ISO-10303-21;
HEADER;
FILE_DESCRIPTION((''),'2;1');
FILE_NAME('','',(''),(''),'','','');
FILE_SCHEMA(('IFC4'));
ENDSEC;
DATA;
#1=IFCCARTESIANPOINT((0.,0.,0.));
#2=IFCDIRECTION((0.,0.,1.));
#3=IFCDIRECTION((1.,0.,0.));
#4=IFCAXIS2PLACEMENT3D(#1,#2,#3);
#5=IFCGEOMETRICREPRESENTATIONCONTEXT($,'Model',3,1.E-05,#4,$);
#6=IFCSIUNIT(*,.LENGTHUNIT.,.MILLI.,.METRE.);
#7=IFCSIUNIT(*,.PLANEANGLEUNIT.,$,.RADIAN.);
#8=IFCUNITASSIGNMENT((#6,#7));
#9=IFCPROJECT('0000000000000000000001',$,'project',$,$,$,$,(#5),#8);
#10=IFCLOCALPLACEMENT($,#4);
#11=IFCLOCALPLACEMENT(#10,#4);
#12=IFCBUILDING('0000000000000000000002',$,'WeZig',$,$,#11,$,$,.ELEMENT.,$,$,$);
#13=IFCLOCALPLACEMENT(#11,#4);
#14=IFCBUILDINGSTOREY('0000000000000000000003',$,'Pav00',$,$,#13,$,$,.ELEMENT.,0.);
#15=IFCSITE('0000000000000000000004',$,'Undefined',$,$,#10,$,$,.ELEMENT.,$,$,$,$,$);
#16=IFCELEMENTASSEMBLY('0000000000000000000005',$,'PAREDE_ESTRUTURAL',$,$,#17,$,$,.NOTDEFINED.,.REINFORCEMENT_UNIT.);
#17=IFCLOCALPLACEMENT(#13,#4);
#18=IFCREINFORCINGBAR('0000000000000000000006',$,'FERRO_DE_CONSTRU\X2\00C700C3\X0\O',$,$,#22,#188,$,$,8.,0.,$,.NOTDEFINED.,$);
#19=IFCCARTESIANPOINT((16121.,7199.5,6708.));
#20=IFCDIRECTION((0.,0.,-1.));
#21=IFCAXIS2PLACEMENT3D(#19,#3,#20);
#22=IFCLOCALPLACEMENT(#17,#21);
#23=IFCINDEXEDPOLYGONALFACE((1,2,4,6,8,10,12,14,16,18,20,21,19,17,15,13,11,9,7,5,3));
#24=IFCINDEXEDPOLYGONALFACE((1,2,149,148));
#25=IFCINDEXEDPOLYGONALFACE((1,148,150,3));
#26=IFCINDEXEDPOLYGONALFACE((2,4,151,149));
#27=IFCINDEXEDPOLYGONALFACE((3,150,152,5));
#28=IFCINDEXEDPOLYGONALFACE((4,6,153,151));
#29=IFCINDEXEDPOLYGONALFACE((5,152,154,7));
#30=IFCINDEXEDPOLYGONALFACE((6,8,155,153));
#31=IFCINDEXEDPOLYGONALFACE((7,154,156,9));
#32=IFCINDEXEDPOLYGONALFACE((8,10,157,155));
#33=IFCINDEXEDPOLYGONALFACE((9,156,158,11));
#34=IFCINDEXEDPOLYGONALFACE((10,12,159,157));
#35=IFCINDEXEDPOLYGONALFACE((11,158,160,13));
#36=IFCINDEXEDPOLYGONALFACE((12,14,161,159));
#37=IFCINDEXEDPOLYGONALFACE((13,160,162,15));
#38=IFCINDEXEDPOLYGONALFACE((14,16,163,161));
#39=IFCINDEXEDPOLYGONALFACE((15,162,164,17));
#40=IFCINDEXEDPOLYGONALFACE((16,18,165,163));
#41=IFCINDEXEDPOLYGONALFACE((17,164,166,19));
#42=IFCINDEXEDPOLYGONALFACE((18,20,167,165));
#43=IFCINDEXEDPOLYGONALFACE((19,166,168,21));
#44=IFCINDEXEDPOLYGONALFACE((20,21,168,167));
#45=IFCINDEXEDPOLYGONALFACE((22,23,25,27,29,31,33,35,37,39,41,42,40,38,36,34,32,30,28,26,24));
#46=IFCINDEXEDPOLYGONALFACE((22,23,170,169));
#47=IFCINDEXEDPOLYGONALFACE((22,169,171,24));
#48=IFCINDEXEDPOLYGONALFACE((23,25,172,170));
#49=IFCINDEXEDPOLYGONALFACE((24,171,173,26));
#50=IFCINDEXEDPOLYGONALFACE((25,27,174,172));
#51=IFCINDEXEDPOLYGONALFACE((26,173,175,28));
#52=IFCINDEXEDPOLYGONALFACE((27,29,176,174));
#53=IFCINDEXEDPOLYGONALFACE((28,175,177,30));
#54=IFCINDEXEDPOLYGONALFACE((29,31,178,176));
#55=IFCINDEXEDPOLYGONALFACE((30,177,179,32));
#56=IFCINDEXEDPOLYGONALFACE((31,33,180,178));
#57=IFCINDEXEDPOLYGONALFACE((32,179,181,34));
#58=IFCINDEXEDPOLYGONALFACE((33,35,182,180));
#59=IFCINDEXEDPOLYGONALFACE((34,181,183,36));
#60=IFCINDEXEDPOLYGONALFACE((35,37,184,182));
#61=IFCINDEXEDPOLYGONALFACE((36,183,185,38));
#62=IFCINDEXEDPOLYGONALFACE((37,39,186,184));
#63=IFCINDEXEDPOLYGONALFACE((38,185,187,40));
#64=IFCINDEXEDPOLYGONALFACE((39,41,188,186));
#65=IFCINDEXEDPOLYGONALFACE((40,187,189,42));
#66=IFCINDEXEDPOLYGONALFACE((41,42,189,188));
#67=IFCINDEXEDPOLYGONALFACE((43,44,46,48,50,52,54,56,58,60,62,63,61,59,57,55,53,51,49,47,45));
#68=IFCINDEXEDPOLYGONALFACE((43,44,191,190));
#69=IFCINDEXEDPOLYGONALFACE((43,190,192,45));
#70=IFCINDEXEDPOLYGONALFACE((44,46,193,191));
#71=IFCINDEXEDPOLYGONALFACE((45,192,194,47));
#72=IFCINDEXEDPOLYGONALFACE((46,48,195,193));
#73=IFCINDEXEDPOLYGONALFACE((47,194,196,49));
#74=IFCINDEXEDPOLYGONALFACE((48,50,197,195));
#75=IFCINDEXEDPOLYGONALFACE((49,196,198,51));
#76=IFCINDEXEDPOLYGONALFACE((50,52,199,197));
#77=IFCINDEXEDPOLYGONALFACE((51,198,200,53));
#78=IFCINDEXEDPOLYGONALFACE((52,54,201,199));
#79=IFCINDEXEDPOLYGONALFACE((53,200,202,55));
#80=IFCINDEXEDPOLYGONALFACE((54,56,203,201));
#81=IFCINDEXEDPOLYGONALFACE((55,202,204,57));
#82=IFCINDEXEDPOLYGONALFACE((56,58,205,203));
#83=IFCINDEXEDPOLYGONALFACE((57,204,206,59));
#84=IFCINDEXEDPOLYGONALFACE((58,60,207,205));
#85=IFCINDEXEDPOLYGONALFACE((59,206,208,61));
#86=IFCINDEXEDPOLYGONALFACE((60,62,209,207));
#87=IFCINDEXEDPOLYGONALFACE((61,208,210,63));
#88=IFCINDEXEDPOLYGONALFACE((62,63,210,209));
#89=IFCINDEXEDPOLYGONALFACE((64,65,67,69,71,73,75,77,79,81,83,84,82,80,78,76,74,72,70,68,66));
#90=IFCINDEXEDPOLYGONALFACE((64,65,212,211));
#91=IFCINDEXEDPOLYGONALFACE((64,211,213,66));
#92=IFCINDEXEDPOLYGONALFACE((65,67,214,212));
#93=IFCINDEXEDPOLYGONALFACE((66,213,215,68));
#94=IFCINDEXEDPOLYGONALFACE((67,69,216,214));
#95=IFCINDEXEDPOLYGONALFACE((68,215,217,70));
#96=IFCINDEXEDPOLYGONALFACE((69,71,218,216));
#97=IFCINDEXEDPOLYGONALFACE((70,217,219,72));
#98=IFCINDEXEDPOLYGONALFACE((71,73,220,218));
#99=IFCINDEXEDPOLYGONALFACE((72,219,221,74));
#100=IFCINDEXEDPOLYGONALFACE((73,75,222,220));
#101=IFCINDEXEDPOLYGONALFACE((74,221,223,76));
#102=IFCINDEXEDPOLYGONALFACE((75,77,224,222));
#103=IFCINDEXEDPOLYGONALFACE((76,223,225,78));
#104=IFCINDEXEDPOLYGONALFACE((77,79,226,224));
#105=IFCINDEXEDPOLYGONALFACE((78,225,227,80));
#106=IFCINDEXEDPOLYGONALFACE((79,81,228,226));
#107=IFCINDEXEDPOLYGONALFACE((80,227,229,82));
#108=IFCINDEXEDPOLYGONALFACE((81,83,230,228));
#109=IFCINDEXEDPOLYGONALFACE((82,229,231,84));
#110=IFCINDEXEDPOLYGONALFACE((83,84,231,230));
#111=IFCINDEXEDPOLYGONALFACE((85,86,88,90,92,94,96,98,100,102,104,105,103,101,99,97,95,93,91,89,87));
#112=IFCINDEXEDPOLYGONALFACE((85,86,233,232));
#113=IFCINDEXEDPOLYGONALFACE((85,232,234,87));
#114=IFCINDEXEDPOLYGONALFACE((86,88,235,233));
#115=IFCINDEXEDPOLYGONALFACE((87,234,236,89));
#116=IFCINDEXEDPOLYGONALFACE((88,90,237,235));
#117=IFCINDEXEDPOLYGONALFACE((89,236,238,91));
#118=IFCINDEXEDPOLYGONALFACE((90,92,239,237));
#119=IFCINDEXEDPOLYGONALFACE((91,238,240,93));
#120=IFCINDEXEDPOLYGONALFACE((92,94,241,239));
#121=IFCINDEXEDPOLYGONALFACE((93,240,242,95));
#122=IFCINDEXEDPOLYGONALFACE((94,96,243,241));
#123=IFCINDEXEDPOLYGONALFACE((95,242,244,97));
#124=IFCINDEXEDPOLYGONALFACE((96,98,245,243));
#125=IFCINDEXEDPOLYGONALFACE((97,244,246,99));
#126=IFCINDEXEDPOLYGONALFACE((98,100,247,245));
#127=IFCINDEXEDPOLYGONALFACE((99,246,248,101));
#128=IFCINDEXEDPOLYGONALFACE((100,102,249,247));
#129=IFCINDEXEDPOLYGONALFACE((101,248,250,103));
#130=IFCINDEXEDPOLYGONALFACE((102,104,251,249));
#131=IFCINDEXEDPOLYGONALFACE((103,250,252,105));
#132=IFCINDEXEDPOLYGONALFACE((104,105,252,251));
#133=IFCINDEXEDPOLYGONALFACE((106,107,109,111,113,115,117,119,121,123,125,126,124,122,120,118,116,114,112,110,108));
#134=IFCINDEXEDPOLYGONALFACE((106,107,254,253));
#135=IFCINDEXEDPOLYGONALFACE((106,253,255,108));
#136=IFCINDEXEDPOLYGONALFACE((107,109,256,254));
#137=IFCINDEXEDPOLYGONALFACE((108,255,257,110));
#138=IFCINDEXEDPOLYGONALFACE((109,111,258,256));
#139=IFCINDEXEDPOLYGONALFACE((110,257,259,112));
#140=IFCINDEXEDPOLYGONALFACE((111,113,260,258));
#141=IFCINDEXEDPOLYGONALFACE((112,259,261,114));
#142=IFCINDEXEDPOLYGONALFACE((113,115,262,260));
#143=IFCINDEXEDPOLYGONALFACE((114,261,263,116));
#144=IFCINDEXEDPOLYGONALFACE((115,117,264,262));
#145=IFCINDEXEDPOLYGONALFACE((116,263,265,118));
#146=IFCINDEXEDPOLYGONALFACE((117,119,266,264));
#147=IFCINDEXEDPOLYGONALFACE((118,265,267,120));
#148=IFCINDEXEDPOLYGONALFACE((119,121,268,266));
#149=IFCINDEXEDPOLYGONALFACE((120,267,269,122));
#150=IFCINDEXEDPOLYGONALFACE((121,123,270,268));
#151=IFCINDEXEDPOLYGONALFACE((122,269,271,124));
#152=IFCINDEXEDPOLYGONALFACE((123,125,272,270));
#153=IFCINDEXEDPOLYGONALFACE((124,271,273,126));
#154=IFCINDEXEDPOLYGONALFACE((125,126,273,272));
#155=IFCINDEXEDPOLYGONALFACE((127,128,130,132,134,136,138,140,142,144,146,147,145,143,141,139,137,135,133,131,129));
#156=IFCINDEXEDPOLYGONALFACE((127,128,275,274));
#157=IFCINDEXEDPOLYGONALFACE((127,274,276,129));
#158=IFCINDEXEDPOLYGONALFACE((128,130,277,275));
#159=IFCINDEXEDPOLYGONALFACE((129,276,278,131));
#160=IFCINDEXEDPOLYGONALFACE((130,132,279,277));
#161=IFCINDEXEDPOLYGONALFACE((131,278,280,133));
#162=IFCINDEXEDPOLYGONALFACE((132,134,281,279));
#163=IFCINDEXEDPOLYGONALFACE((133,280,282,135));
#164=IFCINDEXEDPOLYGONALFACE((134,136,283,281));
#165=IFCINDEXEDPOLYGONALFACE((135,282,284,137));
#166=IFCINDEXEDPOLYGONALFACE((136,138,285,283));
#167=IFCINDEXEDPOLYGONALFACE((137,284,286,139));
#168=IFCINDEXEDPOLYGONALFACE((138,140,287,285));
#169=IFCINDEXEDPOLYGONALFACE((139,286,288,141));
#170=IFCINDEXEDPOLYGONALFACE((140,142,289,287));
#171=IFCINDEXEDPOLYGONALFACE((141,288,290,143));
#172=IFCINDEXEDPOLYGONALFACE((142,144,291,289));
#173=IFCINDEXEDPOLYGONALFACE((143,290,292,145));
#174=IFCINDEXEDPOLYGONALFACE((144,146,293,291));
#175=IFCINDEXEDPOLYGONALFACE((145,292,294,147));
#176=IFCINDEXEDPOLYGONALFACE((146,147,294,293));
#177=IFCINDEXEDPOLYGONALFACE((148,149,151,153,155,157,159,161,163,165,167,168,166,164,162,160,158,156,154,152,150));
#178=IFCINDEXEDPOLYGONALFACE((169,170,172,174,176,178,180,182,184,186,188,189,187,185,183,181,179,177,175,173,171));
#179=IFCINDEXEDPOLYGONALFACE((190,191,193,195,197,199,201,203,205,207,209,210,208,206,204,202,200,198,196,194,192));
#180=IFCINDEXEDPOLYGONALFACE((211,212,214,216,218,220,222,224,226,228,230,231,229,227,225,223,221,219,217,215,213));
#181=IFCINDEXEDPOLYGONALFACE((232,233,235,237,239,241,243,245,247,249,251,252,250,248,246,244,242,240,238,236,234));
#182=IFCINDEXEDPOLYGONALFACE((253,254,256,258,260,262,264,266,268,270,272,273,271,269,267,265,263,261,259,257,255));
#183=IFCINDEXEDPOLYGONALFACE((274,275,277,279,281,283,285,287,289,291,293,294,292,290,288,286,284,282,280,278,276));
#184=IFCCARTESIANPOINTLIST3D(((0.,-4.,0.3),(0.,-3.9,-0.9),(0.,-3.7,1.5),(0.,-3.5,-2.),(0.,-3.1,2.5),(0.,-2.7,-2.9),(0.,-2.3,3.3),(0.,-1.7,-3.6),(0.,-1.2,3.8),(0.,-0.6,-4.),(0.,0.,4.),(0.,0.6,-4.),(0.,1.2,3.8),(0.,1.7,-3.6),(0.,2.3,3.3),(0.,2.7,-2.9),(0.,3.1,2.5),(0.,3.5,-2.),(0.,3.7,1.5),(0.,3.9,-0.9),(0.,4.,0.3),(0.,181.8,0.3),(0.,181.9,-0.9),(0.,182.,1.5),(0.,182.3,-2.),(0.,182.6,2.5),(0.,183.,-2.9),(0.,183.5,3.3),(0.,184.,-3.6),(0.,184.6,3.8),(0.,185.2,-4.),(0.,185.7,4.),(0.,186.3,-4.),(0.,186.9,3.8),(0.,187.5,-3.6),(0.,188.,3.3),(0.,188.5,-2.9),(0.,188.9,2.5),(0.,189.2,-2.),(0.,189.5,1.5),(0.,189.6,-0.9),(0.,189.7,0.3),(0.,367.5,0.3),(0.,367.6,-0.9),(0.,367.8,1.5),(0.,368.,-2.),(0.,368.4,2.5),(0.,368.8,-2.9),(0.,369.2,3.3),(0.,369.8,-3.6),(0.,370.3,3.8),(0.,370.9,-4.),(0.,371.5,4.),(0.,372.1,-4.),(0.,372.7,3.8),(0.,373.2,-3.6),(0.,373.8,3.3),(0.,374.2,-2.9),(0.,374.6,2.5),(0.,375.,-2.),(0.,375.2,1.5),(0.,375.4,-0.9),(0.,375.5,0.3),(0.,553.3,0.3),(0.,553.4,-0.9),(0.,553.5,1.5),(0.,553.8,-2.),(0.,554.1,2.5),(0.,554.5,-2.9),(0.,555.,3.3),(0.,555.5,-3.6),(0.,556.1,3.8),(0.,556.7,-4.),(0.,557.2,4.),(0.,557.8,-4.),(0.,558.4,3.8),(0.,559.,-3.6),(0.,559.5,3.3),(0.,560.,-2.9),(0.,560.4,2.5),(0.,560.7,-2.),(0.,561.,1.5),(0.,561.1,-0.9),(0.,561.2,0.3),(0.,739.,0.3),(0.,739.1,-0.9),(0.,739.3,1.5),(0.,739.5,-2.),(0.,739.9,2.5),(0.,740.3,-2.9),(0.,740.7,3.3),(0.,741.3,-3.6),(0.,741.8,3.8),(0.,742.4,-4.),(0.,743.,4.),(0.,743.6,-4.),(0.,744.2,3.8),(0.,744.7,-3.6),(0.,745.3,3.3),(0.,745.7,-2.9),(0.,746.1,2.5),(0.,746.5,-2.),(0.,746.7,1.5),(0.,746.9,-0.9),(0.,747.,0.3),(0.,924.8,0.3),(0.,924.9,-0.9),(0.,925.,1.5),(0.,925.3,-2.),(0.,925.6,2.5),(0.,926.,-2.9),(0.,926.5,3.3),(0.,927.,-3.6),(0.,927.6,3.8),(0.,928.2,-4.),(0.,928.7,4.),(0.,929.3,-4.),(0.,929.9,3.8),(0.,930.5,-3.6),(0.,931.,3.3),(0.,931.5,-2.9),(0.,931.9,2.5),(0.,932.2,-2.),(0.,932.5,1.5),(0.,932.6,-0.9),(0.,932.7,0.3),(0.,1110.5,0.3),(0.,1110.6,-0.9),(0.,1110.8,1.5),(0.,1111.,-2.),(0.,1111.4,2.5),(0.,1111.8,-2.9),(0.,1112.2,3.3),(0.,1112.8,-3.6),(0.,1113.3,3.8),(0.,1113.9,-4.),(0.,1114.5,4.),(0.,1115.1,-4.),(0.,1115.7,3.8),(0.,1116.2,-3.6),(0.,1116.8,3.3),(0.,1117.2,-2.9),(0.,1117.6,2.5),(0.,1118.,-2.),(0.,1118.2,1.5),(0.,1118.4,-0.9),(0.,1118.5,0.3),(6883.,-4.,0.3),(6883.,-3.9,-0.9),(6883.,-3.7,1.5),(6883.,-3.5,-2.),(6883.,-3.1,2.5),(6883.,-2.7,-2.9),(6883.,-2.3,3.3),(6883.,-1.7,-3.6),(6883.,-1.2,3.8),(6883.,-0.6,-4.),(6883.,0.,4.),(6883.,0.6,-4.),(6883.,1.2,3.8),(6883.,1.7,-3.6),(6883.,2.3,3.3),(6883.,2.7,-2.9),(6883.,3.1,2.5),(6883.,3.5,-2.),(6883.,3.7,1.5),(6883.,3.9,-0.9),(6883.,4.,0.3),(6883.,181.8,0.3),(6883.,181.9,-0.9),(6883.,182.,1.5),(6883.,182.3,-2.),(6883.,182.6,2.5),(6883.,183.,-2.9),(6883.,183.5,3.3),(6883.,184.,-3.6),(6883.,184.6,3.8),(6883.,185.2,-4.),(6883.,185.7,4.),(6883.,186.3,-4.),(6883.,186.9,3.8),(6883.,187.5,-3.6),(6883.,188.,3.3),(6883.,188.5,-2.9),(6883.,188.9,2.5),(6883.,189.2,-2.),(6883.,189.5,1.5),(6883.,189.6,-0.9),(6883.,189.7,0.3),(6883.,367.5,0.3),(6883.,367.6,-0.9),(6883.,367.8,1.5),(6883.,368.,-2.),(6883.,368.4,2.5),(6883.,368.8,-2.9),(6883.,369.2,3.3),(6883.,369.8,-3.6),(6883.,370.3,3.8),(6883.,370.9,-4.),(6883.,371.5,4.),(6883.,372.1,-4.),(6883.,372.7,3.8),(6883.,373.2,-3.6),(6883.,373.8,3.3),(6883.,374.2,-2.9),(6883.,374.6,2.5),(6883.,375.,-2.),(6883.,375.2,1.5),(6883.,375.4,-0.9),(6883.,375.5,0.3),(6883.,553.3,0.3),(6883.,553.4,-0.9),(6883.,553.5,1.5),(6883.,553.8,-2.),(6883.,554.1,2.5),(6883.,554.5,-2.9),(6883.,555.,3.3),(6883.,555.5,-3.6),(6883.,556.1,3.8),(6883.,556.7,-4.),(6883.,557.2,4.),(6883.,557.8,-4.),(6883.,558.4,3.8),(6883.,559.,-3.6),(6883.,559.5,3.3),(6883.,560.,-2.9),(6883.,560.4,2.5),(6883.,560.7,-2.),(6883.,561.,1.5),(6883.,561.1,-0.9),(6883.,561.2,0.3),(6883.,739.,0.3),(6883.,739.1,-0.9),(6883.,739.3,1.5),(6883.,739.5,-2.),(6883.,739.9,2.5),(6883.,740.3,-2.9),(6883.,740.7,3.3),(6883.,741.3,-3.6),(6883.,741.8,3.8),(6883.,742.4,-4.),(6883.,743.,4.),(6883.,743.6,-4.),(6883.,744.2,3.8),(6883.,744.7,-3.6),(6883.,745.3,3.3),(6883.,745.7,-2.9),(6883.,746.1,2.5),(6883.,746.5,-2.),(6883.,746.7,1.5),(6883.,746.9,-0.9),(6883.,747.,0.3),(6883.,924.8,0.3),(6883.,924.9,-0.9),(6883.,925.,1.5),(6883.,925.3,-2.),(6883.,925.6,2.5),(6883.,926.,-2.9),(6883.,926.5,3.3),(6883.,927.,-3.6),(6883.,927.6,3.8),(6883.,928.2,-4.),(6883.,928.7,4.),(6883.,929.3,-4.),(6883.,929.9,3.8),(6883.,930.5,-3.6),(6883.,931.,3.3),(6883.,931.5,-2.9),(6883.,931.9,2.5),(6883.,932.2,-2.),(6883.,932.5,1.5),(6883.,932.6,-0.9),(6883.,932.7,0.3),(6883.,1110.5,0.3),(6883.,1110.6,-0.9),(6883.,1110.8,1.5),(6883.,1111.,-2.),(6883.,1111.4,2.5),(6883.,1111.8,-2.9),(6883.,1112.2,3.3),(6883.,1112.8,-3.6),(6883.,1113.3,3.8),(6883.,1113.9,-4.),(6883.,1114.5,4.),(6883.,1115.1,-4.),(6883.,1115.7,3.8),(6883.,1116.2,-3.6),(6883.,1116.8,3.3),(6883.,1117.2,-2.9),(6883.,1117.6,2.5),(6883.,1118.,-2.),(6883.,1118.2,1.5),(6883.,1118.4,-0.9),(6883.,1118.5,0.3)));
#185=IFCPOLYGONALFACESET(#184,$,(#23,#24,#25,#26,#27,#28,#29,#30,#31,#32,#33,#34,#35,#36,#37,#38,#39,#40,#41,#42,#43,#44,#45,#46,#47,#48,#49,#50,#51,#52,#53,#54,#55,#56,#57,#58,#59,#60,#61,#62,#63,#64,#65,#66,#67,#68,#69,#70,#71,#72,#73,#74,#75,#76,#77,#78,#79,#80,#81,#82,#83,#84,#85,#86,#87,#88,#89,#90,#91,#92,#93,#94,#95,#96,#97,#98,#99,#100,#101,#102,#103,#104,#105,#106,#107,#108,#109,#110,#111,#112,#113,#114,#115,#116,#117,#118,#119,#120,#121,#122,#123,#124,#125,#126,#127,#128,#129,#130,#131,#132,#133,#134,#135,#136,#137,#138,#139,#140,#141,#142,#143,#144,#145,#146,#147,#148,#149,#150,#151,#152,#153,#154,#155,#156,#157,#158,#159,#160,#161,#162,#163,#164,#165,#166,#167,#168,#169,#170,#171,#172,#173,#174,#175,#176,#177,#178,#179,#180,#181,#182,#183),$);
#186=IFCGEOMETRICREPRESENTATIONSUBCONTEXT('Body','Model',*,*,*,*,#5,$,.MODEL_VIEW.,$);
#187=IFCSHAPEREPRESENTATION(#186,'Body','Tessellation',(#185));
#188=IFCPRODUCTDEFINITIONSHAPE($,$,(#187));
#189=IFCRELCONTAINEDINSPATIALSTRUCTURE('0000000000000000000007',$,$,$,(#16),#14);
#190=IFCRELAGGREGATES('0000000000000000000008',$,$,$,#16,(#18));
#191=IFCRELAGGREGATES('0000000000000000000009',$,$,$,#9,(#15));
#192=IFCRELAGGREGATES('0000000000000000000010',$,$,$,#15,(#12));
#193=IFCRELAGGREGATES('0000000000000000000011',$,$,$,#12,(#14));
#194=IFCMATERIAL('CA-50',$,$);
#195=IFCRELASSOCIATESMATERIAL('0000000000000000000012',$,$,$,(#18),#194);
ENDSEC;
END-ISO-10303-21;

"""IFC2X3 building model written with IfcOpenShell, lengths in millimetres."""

from ifc_helpers import new_model, entity, si_unit, frame, origin_with_axes, place, context, subcontext, project, spatial, source, transform, mapped, material, element, aggregate, save


model = new_model("IFC2X3")

# Units and contexts
model_context = context("Model", 3, precision=1e-05, world=origin_with_axes())
body_context = subcontext(model_context, "Body", "Model", "MODEL_VIEW")
ifc_project = project(units=[si_unit("LENGTHUNIT", "METRE", prefix="MILLI"), si_unit("PLANEANGLEUNIT", "RADIAN")], contexts=[model_context])

# Site, building, storey
site_placement = place(None, origin_with_axes())
site = spatial("IfcSite", under=ifc_project, at=site_placement, Name="Undefined", CompositionType="ELEMENT")
building_placement = place(site_placement, origin_with_axes())
building = spatial("IfcBuilding", under=site, at=building_placement, Name="WeZig", CompositionType="ELEMENT")
storey_placement = place(building_placement, origin_with_axes())
storey = spatial("IfcBuildingStorey", under=building, at=storey_placement, Name="Pav00", CompositionType="ELEMENT", Elevation=0.0)

# Shared definitions
ifc_material_1 = material(Name="CA-50")

# Element assembly, reinforcing bar
assembly_1_placement = place(storey_placement, origin_with_axes())
assembly_1 = element("IfcElementAssembly", 1, at=assembly_1_placement, inside=storey, Name="PAREDE_ESTRUTURAL", AssemblyPlace="NOTDEFINED", PredefinedType="REINFORCEMENT_UNIT")
shared_shape_1 = source(origin_with_axes(), body_context, "Body", "AdvancedSweptSolid", [
    entity("IfcSweptDiskSolid", entity("IfcTrimmedCurve", entity("IfcLine", entity("IfcCartesianPoint", [0.0, 0.0, 0.0]), entity("IfcVector", entity("IfcDirection", [1.0, 0.0, 0.0]), 1.0)), [entity("IfcParameterValue", 0.0)], [entity("IfcParameterValue", 6883.0)], True, "PARAMETER"), 4.0, None, 0.0, 6883.0),
])
shared_shape_2 = source(origin_with_axes(), body_context, "Body", "AdvancedSweptSolid", [
    entity("IfcSweptDiskSolid", entity("IfcTrimmedCurve", entity("IfcLine", entity("IfcCartesianPoint", [0.0, 0.0, 0.0]), entity("IfcVector", entity("IfcDirection", [1.0, 0.0, 0.0]), 1.0)), [entity("IfcParameterValue", 0.0)], [entity("IfcParameterValue", 6883.0)], True, "PARAMETER"), 4.0, None, 0.0, 6883.0),
])
shared_shape_3 = source(origin_with_axes(), body_context, "Body", "AdvancedSweptSolid", [
    entity("IfcSweptDiskSolid", entity("IfcTrimmedCurve", entity("IfcLine", entity("IfcCartesianPoint", [0.0, 0.0, 0.0]), entity("IfcVector", entity("IfcDirection", [1.0, 0.0, 0.0]), 1.0)), [entity("IfcParameterValue", 0.0)], [entity("IfcParameterValue", 6883.0)], True, "PARAMETER"), 4.0, None, 0.0, 6883.0),
])
shared_shape_4 = source(origin_with_axes(), body_context, "Body", "AdvancedSweptSolid", [
    entity("IfcSweptDiskSolid", entity("IfcTrimmedCurve", entity("IfcLine", entity("IfcCartesianPoint", [0.0, 0.0, 0.0]), entity("IfcVector", entity("IfcDirection", [1.0, 0.0, 0.0]), 1.0)), [entity("IfcParameterValue", 0.0)], [entity("IfcParameterValue", 6883.0)], True, "PARAMETER"), 4.0, None, 0.0, 6883.0),
])
shared_shape_5 = source(origin_with_axes(), body_context, "Body", "AdvancedSweptSolid", [
    entity("IfcSweptDiskSolid", entity("IfcTrimmedCurve", entity("IfcLine", entity("IfcCartesianPoint", [0.0, 0.0, 0.0]), entity("IfcVector", entity("IfcDirection", [1.0, 0.0, 0.0]), 1.0)), [entity("IfcParameterValue", 0.0)], [entity("IfcParameterValue", 6883.0)], True, "PARAMETER"), 4.0, None, 0.0, 6883.0),
])
shared_shape_6 = source(origin_with_axes(), body_context, "Body", "AdvancedSweptSolid", [
    entity("IfcSweptDiskSolid", entity("IfcTrimmedCurve", entity("IfcLine", entity("IfcCartesianPoint", [0.0, 0.0, 0.0]), entity("IfcVector", entity("IfcDirection", [1.0, 0.0, 0.0]), 1.0)), [entity("IfcParameterValue", 0.0)], [entity("IfcParameterValue", 6883.0)], True, "PARAMETER"), 4.0, None, 0.0, 6883.0),
])
shared_shape_7 = source(origin_with_axes(), body_context, "Body", "AdvancedSweptSolid", [
    entity("IfcSweptDiskSolid", entity("IfcTrimmedCurve", entity("IfcLine", entity("IfcCartesianPoint", [0.0, 0.0, 0.0]), entity("IfcVector", entity("IfcDirection", [1.0, 0.0, 0.0]), 1.0)), [entity("IfcParameterValue", 0.0)], [entity("IfcParameterValue", 6883.0)], True, "PARAMETER"), 4.0, None, 0.0, 6883.0),
])
reinforcing_bar_1_placement = place(assembly_1_placement, frame((16121.0, 7199.5, 6708.0), z_axis=(1.0, 0.0, 0.0), x_axis=(0.0, 0.0, -1.0)))
reinforcing_bar_1 = element("IfcReinforcingBar", 2, at=reinforcing_bar_1_placement, material=ifc_material_1, Name="FERRO_DE_CONSTRUÇÃO", BarRole="NOTDEFINED", CrossSectionArea=0.0, NominalDiameter=8.0, context=body_context, shape_type="MappedRepresentation", body=[
    mapped(shared_shape_1, transform((0.0, 0.0, 0.0))),
    mapped(shared_shape_2, transform((0.0, 185.7, 0.0))),
    mapped(shared_shape_3, transform((0.0, 371.5, 0.0))),
    mapped(shared_shape_4, transform((0.0, 557.2, 0.0))),
    mapped(shared_shape_5, transform((0.0, 743.0, 0.0))),
    mapped(shared_shape_6, transform((0.0, 928.7, 0.0))),
    mapped(shared_shape_7, transform((0.0, 1114.5, 0.0))),
])
aggregate(assembly_1, [reinforcing_bar_1])

save(model, "model.ifc")
